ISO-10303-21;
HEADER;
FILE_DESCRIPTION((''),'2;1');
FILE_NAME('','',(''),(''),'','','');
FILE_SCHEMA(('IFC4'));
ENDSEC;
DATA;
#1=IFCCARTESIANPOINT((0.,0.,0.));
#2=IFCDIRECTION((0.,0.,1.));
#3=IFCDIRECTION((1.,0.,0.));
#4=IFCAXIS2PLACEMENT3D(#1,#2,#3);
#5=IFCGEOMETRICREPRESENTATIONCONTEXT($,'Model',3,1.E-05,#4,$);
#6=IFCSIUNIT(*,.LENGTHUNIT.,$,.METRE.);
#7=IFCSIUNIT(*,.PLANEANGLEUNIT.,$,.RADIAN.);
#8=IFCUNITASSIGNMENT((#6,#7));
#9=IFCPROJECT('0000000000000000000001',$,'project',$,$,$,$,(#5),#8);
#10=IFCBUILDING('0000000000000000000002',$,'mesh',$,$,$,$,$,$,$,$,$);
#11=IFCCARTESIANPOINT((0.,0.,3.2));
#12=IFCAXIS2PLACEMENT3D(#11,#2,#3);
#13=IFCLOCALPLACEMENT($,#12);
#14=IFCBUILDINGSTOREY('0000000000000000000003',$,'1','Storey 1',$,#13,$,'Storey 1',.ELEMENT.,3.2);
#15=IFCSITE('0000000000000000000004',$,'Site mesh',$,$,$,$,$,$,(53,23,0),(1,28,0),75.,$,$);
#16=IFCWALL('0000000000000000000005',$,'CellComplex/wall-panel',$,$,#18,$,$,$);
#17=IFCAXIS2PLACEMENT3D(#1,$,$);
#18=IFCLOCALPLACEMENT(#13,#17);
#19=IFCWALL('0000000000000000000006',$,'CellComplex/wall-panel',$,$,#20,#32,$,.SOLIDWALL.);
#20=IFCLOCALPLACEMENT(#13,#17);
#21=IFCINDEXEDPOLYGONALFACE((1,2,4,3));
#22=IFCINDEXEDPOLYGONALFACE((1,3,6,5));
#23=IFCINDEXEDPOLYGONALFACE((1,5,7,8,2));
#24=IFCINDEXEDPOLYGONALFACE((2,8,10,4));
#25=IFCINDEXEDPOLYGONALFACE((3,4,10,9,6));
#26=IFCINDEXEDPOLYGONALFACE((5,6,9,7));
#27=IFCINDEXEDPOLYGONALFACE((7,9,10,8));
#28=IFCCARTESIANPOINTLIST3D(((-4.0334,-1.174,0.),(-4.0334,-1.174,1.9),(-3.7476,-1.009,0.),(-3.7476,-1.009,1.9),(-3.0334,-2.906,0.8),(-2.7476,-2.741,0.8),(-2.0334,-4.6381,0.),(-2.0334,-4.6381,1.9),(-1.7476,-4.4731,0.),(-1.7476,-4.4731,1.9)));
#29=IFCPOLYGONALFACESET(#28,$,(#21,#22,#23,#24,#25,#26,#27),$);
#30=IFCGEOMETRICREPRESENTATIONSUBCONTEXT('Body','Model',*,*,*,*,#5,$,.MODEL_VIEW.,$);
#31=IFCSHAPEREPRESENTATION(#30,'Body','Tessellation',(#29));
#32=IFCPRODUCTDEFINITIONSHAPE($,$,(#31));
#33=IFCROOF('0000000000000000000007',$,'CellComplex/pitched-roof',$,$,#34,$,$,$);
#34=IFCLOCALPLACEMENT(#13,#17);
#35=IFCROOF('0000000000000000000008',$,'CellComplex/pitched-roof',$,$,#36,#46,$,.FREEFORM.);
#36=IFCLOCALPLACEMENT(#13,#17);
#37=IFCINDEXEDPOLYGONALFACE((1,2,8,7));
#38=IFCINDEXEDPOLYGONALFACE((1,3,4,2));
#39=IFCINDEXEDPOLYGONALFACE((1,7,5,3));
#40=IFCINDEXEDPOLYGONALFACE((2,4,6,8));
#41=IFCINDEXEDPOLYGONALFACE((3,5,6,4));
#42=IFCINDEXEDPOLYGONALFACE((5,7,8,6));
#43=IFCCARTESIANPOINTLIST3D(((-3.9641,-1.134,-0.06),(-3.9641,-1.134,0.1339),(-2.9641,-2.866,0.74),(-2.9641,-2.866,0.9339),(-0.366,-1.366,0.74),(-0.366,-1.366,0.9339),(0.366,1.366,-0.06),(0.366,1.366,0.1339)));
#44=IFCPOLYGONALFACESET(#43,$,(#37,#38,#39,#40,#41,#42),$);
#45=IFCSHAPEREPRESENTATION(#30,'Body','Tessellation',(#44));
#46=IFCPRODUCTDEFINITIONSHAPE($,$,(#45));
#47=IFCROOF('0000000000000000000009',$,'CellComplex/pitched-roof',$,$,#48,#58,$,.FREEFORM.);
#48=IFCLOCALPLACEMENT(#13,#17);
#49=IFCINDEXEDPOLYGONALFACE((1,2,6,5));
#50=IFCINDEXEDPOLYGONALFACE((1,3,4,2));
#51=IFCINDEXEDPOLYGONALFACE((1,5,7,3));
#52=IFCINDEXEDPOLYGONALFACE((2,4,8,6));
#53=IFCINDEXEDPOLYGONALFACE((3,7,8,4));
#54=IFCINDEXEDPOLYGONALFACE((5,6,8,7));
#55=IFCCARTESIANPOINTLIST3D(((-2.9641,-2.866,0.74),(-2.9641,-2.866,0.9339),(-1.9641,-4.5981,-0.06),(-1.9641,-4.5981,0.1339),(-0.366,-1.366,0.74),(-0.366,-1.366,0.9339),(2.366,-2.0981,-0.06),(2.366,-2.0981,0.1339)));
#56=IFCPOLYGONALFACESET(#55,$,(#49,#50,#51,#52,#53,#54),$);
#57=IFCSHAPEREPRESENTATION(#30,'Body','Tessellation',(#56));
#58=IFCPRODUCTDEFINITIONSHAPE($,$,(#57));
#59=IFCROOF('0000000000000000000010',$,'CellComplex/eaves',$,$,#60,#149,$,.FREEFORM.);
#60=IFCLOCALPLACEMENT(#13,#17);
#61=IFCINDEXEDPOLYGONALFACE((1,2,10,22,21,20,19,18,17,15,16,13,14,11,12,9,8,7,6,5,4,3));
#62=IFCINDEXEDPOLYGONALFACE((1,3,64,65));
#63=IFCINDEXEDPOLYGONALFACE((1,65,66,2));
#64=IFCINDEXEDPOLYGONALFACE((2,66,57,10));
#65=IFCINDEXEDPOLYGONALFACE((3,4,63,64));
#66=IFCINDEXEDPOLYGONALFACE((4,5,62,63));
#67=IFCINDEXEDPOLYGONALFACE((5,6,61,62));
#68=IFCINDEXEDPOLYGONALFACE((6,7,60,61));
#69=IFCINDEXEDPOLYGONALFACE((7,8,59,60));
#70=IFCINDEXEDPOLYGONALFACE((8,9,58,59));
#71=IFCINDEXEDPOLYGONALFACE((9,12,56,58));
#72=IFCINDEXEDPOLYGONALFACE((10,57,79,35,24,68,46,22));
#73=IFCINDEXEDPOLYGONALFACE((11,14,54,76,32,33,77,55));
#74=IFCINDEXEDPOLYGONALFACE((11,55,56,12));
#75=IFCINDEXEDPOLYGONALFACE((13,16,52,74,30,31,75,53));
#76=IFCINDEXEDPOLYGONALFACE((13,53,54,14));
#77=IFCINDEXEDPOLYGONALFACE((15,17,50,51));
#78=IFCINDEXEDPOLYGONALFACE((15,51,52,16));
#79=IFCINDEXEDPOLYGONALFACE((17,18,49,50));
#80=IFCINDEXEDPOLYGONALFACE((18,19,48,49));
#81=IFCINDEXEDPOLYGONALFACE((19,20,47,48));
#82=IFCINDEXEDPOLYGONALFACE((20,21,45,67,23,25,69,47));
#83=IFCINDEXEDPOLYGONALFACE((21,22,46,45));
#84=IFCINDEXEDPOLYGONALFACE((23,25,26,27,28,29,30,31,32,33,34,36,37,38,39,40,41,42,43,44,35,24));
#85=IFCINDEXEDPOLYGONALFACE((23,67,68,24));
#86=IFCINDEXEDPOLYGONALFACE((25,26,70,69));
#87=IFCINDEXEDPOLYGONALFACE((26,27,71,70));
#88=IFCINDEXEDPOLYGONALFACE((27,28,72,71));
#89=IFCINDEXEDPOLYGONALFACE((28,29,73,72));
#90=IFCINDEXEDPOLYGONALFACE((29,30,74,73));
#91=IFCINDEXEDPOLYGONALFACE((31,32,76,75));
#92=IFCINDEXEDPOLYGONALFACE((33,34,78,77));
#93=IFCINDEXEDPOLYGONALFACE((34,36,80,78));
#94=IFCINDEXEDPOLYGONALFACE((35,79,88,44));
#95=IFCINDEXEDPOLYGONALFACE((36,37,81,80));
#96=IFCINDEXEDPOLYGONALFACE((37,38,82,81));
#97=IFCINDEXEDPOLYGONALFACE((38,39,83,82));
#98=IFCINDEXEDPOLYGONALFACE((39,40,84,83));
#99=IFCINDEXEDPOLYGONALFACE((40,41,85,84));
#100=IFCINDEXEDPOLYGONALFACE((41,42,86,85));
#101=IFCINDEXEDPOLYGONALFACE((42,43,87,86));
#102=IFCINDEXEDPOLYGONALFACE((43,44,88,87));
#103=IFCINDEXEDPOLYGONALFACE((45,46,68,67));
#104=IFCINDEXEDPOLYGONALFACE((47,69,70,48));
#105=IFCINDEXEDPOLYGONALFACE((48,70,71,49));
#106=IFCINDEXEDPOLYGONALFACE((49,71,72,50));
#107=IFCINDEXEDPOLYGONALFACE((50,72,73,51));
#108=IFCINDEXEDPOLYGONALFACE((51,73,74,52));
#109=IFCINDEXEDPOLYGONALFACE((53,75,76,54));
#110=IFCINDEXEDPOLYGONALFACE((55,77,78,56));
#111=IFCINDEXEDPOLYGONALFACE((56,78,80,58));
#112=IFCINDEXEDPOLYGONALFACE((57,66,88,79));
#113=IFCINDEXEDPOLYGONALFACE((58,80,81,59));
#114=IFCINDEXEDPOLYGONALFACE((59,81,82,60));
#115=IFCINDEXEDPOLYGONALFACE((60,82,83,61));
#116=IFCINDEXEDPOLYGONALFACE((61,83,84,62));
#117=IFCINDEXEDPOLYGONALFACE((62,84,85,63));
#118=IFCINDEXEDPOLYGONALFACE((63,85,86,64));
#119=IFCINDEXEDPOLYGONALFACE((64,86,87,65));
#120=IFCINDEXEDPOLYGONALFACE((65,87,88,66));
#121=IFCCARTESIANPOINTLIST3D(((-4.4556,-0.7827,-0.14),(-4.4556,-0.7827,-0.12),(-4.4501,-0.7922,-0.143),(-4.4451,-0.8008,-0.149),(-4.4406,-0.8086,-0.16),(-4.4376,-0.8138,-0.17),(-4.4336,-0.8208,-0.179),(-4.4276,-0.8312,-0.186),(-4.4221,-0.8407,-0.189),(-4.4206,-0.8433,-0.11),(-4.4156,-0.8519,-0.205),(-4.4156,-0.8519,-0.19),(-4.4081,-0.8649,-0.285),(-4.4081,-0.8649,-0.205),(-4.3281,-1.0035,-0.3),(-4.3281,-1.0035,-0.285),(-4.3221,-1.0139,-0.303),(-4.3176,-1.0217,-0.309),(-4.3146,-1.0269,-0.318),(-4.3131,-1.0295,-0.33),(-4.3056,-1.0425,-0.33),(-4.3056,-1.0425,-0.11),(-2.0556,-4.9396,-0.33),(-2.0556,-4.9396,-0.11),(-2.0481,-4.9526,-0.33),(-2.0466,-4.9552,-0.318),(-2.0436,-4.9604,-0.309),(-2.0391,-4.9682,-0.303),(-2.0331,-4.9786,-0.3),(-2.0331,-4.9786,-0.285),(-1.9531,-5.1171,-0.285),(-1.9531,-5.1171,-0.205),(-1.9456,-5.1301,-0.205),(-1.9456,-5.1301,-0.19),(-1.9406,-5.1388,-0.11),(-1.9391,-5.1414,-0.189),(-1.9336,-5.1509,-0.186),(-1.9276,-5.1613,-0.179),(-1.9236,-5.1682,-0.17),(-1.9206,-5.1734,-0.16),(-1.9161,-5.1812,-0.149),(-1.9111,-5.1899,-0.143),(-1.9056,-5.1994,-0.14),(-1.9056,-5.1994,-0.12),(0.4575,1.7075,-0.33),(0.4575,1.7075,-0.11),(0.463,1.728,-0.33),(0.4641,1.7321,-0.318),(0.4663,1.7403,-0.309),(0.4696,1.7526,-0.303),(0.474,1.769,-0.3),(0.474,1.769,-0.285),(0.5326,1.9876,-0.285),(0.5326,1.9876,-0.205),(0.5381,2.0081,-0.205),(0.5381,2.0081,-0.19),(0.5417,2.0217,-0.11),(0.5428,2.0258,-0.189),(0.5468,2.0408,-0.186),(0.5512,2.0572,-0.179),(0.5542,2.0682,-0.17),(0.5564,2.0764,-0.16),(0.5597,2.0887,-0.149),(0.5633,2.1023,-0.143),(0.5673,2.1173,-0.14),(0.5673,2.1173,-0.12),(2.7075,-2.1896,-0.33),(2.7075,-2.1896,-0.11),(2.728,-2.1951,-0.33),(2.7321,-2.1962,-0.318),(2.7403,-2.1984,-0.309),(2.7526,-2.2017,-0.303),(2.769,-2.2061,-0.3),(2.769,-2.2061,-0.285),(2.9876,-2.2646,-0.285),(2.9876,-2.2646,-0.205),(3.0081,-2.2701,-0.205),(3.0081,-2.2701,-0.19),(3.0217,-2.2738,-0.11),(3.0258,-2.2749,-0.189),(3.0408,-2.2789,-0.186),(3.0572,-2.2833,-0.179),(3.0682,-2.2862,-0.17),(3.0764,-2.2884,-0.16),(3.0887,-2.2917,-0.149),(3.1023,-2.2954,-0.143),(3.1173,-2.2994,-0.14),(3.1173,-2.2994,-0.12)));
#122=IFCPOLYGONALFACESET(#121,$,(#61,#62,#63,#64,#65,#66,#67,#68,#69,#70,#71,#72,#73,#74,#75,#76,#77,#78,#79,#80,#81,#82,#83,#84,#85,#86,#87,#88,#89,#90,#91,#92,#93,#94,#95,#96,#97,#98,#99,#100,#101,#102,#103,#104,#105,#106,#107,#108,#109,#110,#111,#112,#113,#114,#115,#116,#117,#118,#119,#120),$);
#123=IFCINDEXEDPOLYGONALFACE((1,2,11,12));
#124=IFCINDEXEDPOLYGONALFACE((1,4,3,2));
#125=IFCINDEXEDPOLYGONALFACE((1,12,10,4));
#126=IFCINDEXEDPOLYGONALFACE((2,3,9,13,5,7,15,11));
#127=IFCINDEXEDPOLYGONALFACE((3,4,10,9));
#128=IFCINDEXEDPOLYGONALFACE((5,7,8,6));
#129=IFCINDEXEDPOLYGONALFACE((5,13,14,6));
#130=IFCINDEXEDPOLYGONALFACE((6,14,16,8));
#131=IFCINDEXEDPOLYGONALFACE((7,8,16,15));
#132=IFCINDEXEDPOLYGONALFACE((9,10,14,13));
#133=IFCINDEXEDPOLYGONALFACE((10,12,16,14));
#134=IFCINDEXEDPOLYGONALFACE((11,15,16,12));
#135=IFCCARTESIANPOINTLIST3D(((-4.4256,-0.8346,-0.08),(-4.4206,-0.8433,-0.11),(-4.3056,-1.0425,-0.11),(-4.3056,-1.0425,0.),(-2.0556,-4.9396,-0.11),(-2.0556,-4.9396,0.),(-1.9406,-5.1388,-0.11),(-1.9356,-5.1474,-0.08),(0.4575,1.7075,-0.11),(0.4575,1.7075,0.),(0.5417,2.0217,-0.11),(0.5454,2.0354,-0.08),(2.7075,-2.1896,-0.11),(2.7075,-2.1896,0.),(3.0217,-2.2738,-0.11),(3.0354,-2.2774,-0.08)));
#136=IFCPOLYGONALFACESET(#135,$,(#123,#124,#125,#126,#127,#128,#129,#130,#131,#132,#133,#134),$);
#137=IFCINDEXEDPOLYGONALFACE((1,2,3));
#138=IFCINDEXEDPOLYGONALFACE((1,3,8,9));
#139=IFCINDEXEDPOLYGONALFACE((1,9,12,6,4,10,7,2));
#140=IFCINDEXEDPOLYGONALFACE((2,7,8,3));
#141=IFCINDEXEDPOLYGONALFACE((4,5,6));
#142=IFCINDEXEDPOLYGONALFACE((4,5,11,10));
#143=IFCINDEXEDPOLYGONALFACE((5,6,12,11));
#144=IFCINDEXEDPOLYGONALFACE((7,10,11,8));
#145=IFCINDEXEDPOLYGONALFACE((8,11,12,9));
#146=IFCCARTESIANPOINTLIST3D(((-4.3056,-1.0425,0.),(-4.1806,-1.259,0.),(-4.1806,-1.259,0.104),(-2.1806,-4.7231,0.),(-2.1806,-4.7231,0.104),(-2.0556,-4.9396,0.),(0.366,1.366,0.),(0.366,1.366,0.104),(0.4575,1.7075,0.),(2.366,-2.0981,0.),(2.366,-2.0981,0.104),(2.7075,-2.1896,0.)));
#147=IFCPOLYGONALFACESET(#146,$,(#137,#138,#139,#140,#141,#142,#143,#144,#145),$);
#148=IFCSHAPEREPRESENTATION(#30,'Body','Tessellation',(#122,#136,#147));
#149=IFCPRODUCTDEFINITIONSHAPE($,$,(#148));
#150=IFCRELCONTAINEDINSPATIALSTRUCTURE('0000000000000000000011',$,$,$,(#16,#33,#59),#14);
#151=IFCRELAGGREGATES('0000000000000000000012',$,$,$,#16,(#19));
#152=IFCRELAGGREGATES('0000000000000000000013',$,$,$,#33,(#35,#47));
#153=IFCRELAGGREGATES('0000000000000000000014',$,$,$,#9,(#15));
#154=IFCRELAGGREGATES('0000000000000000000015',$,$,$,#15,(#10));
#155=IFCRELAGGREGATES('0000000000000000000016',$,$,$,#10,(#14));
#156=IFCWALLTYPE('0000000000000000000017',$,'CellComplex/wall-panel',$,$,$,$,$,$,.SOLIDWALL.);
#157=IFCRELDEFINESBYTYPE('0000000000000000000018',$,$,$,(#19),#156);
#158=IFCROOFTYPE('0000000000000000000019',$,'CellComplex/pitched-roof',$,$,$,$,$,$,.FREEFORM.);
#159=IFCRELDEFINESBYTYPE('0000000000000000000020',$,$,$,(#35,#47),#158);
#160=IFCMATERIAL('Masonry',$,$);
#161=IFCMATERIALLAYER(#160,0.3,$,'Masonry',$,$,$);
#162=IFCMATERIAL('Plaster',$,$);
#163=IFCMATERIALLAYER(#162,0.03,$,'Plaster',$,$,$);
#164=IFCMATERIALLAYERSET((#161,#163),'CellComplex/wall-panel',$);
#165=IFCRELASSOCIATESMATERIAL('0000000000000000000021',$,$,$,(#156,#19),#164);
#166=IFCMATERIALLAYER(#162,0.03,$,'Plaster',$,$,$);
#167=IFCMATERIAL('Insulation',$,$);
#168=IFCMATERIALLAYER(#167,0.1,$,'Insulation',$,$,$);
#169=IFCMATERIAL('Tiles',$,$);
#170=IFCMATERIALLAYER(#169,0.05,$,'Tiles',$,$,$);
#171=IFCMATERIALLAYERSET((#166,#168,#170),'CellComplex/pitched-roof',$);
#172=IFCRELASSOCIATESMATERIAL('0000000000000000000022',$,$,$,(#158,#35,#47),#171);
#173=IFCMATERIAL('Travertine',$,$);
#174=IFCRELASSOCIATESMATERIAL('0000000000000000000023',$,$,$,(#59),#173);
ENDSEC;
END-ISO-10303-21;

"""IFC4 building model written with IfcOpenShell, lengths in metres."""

from ifc_helpers import new_model, entity, si_unit, frame, origin, origin_with_axes, place, context, subcontext, project, spatial, polyline, outline, extrude, material, layer, layer_set, layer_usage, type_object, element, aggregate, save


model = new_model("IFC4")

# Units and contexts
model_context = context("Model", 3, precision=1e-05, world=origin_with_axes())
body_context = subcontext(model_context, "Body", "Model", "MODEL_VIEW")
ifc_project = project(units=[si_unit("LENGTHUNIT", "METRE"), si_unit("PLANEANGLEUNIT", "RADIAN")], contexts=[model_context])

# Site, building, storey
site = spatial("IfcSite", under=ifc_project, Name="Site mesh", RefLatitude=(53, 23, 0), RefLongitude=(1, 28, 0), RefElevation=75.0)
building = spatial("IfcBuilding", under=site, Name="mesh")
storey_placement = place(None, frame((0.0, 0.0, 3.2), z_axis=(0.0, 0.0, 1.0), x_axis=(1.0, 0.0, 0.0)))
storey = spatial("IfcBuildingStorey", under=building, at=storey_placement, Name="1", Description="Storey 1", LongName="Storey 1", CompositionType="ELEMENT", Elevation=3.2)

# Shared definitions
ifc_material_1 = material(Name="Masonry")
ifc_material_2 = material(Name="Plaster")

# Walls
wall_1_placement = place(storey_placement, frame((0.0, 0.0, -3.2), z_axis=(0.0, 0.0, 1.0), x_axis=(1.0, 0.0, 0.0)))
wall_1 = element("IfcWall", 1, at=wall_1_placement, inside=storey, Name="CellComplex/wall-panel")
ifc_layer_1 = layer(ifc_material_1, 0.3, Name="Masonry")
ifc_layer_2 = layer(ifc_material_2, 0.03, Name="Plaster")
ifc_layer_set_1 = layer_set([ifc_layer_1, ifc_layer_2], Name="CellComplex/wall-panel")
ifc_layer_usage_1 = layer_usage(ifc_layer_set_1, "AXIS2", "POSITIVE", 0.0)
wall_type_1 = type_object("IfcWallType", Name="CellComplex/wall-panel", PredefinedType="SOLIDWALL", material=ifc_layer_set_1)
wall_2_placement = place(wall_1_placement, frame((-2.0334, -4.6381, 5.1), z_axis=(0.866025, 0.5, 0.0), x_axis=(-0.5, 0.866025, 0.0)))
wall_2 = element("IfcWall", 2, at=wall_2_placement, type_object=wall_type_1, material=ifc_layer_usage_1, Name="CellComplex/wall-panel", PredefinedType="SOLIDWALL", context=body_context, shape_type="SweptSolid", body=[
    extrude(outline(polyline([(0.0, 0.0), (0.0, -1.9), (2.0, -1.1), (4.0, -1.9), (4.0, 0.0), (0.0, 0.0)])), origin(), (0.0, 0.0, 1.0), 0.33),
])
aggregate(wall_1, [wall_2])

# Roofs
roof_1_placement = place(storey_placement, frame((0.0, 0.0, -3.2), z_axis=(0.0, 0.0, 1.0), x_axis=(1.0, 0.0, 0.0)))
roof_1 = element("IfcRoof", 3, at=roof_1_placement, inside=storey, Name="CellComplex/pitched-roof")
ifc_layer_3 = layer(ifc_material_2, 0.03, Name="Plaster")
ifc_material_3 = material(Name="Insulation")
ifc_layer_4 = layer(ifc_material_3, 0.1, Name="Insulation")
ifc_material_4 = material(Name="Tiles")
ifc_layer_5 = layer(ifc_material_4, 0.05, Name="Tiles")
ifc_layer_set_2 = layer_set([ifc_layer_3, ifc_layer_4, ifc_layer_5], Name="CellComplex/pitched-roof")
roof_type = type_object("IfcRoofType", Name="CellComplex/pitched-roof", PredefinedType="FREEFORM", material=ifc_layer_set_2)
ifc_layer_usage_2 = layer_usage(ifc_layer_set_2, "AXIS3", "POSITIVE", 0.0)
roof_2_placement = place(roof_1_placement, frame((0.366, 1.366, 3.14), z_axis=(-0.185695, 0.321634, 0.928477), x_axis=(-0.866025, -0.5, 0.0)))
roof_2 = element("IfcRoof", 4, at=roof_2_placement, type_object=roof_type, material=ifc_layer_usage_2, Name="CellComplex/pitched-roof", PredefinedType="FREEFORM", context=body_context, shape_type="SweptSolid", body=[
    extrude(outline(polyline([(0.0, 0.0), (5.0, 0.0), (5.0, 2.1541), (2.0, 2.1541), (0.0, 0.0)])), origin(), (0.0, 0.371391, 0.928477), 0.1939),
])
ifc_layer_usage_3 = layer_usage(ifc_layer_set_2, "AXIS3", "POSITIVE", 0.0)
roof_3_placement = place(roof_1_placement, frame((-2.9641, -2.866, 3.94), z_axis=(0.185695, -0.321634, 0.928477), x_axis=(0.866025, 0.5, 0.0)))
roof_3 = element("IfcRoof", 5, at=roof_3_placement, type_object=roof_type, material=ifc_layer_usage_3, Name="CellComplex/pitched-roof", PredefinedType="FREEFORM", context=body_context, shape_type="SweptSolid", body=[
    extrude(outline(polyline([(0.0, 0.0), (0.0, -2.1541), (5.0, -2.1541), (3.0, 0.0), (0.0, 0.0)])), origin(), (0.0, 0.371391, 0.928477), 0.1939),
])
aggregate(roof_1, [roof_2, roof_3])

# Roof
ifc_material_5 = material(Name="Travertine")
roof_4_placement = place(storey_placement, origin_with_axes())
axis2_placement3_d_1 = entity("IfcAxis2Placement3D", entity("IfcCartesianPoint", [0.0, 0.0, 0.0]))
axis2_placement3_d_2 = entity("IfcAxis2Placement3D", entity("IfcCartesianPoint", [0.0, 0.0, 0.0]))
axis2_placement3_d_3 = entity("IfcAxis2Placement3D", entity("IfcCartesianPoint", [0.0, 0.0, 0.0]))
element("IfcRoof", 6, at=roof_4_placement, inside=storey, material=ifc_material_5, Name="CellComplex/eaves", PredefinedType="FREEFORM", context=body_context, shape_type="AdvancedSweptSolid", body=[
    entity("IfcSurfaceCurveSweptAreaSolid", entity("IfcDerivedProfileDef", "AREA", None, entity("IfcArbitraryClosedProfileDef", "AREA", None, entity("IfcPolyline", [entity("IfcCartesianPoint", [-0.11, 0.25]), entity("IfcCartesianPoint", [-0.33, 0.25]), entity("IfcCartesianPoint", [-0.33, 0.265]), entity("IfcCartesianPoint", [-0.318, 0.268]), entity("IfcCartesianPoint", [-0.309, 0.274]), entity("IfcCartesianPoint", [-0.303, 0.283]), entity("IfcCartesianPoint", [-0.3, 0.295]), entity("IfcCartesianPoint", [-0.285, 0.295]), entity("IfcCartesianPoint", [-0.285, 0.455]), entity("IfcCartesianPoint", [-0.205, 0.455]), entity("IfcCartesianPoint", [-0.205, 0.47]), entity("IfcCartesianPoint", [-0.19, 0.47]), entity("IfcCartesianPoint", [-0.189, 0.483]), entity("IfcCartesianPoint", [-0.186, 0.494]), entity("IfcCartesianPoint", [-0.179, 0.506]), entity("IfcCartesianPoint", [-0.17, 0.514]), entity("IfcCartesianPoint", [-0.16, 0.52]), entity("IfcCartesianPoint", [-0.149, 0.529]), entity("IfcCartesianPoint", [-0.143, 0.539]), entity("IfcCartesianPoint", [-0.14, 0.55]), entity("IfcCartesianPoint", [-0.12, 0.55]), entity("IfcCartesianPoint", [-0.11, 0.48]), entity("IfcCartesianPoint", [-0.11, 0.25])])), entity("IfcCartesianTransformationOperator2D", None, None, entity("IfcCartesianPoint", [0.0, 0.0]), 1.0)), axis2_placement3_d_1, entity("IfcPolyline", [entity("IfcCartesianPoint", [-2.1806, -4.7231]), entity("IfcCartesianPoint", [2.366, -2.0981]), entity("IfcCartesianPoint", [0.366, 1.366]), entity("IfcCartesianPoint", [-4.1806, -1.259])]), 0.0, 1.0, entity("IfcPlane", axis2_placement3_d_1)),
    entity("IfcSurfaceCurveSweptAreaSolid", entity("IfcDerivedProfileDef", "AREA", None, entity("IfcArbitraryClosedProfileDef", "AREA", None, entity("IfcPolyline", [entity("IfcCartesianPoint", [-0.11, 0.25]), entity("IfcCartesianPoint", [-0.11, 0.48]), entity("IfcCartesianPoint", [-0.08, 0.49]), entity("IfcCartesianPoint", [0.0, 0.25]), entity("IfcCartesianPoint", [-0.11, 0.25])])), entity("IfcCartesianTransformationOperator2D", None, None, entity("IfcCartesianPoint", [0.0, 0.0]), 1.0)), axis2_placement3_d_2, entity("IfcPolyline", [entity("IfcCartesianPoint", [-2.1806, -4.7231]), entity("IfcCartesianPoint", [2.366, -2.0981]), entity("IfcCartesianPoint", [0.366, 1.366]), entity("IfcCartesianPoint", [-4.1806, -1.259])]), 0.0, 1.0, entity("IfcPlane", axis2_placement3_d_2)),
    entity("IfcSurfaceCurveSweptAreaSolid", entity("IfcDerivedProfileDef", "AREA", None, entity("IfcArbitraryClosedProfileDef", "AREA", None, entity("IfcPolyline", [entity("IfcCartesianPoint", [0.0, 0.25]), entity("IfcCartesianPoint", [0.0, 0.0]), entity("IfcCartesianPoint", [0.104, 0.0]), entity("IfcCartesianPoint", [0.0, 0.25])])), entity("IfcCartesianTransformationOperator2D", None, None, entity("IfcCartesianPoint", [0.0, 0.0]), 1.0)), axis2_placement3_d_3, entity("IfcPolyline", [entity("IfcCartesianPoint", [-2.1806, -4.7231]), entity("IfcCartesianPoint", [2.366, -2.0981]), entity("IfcCartesianPoint", [0.366, 1.366]), entity("IfcCartesianPoint", [-4.1806, -1.259])]), 0.0, 1.0, entity("IfcPlane", axis2_placement3_d_3)),
])

save(model, "model.ifc")
